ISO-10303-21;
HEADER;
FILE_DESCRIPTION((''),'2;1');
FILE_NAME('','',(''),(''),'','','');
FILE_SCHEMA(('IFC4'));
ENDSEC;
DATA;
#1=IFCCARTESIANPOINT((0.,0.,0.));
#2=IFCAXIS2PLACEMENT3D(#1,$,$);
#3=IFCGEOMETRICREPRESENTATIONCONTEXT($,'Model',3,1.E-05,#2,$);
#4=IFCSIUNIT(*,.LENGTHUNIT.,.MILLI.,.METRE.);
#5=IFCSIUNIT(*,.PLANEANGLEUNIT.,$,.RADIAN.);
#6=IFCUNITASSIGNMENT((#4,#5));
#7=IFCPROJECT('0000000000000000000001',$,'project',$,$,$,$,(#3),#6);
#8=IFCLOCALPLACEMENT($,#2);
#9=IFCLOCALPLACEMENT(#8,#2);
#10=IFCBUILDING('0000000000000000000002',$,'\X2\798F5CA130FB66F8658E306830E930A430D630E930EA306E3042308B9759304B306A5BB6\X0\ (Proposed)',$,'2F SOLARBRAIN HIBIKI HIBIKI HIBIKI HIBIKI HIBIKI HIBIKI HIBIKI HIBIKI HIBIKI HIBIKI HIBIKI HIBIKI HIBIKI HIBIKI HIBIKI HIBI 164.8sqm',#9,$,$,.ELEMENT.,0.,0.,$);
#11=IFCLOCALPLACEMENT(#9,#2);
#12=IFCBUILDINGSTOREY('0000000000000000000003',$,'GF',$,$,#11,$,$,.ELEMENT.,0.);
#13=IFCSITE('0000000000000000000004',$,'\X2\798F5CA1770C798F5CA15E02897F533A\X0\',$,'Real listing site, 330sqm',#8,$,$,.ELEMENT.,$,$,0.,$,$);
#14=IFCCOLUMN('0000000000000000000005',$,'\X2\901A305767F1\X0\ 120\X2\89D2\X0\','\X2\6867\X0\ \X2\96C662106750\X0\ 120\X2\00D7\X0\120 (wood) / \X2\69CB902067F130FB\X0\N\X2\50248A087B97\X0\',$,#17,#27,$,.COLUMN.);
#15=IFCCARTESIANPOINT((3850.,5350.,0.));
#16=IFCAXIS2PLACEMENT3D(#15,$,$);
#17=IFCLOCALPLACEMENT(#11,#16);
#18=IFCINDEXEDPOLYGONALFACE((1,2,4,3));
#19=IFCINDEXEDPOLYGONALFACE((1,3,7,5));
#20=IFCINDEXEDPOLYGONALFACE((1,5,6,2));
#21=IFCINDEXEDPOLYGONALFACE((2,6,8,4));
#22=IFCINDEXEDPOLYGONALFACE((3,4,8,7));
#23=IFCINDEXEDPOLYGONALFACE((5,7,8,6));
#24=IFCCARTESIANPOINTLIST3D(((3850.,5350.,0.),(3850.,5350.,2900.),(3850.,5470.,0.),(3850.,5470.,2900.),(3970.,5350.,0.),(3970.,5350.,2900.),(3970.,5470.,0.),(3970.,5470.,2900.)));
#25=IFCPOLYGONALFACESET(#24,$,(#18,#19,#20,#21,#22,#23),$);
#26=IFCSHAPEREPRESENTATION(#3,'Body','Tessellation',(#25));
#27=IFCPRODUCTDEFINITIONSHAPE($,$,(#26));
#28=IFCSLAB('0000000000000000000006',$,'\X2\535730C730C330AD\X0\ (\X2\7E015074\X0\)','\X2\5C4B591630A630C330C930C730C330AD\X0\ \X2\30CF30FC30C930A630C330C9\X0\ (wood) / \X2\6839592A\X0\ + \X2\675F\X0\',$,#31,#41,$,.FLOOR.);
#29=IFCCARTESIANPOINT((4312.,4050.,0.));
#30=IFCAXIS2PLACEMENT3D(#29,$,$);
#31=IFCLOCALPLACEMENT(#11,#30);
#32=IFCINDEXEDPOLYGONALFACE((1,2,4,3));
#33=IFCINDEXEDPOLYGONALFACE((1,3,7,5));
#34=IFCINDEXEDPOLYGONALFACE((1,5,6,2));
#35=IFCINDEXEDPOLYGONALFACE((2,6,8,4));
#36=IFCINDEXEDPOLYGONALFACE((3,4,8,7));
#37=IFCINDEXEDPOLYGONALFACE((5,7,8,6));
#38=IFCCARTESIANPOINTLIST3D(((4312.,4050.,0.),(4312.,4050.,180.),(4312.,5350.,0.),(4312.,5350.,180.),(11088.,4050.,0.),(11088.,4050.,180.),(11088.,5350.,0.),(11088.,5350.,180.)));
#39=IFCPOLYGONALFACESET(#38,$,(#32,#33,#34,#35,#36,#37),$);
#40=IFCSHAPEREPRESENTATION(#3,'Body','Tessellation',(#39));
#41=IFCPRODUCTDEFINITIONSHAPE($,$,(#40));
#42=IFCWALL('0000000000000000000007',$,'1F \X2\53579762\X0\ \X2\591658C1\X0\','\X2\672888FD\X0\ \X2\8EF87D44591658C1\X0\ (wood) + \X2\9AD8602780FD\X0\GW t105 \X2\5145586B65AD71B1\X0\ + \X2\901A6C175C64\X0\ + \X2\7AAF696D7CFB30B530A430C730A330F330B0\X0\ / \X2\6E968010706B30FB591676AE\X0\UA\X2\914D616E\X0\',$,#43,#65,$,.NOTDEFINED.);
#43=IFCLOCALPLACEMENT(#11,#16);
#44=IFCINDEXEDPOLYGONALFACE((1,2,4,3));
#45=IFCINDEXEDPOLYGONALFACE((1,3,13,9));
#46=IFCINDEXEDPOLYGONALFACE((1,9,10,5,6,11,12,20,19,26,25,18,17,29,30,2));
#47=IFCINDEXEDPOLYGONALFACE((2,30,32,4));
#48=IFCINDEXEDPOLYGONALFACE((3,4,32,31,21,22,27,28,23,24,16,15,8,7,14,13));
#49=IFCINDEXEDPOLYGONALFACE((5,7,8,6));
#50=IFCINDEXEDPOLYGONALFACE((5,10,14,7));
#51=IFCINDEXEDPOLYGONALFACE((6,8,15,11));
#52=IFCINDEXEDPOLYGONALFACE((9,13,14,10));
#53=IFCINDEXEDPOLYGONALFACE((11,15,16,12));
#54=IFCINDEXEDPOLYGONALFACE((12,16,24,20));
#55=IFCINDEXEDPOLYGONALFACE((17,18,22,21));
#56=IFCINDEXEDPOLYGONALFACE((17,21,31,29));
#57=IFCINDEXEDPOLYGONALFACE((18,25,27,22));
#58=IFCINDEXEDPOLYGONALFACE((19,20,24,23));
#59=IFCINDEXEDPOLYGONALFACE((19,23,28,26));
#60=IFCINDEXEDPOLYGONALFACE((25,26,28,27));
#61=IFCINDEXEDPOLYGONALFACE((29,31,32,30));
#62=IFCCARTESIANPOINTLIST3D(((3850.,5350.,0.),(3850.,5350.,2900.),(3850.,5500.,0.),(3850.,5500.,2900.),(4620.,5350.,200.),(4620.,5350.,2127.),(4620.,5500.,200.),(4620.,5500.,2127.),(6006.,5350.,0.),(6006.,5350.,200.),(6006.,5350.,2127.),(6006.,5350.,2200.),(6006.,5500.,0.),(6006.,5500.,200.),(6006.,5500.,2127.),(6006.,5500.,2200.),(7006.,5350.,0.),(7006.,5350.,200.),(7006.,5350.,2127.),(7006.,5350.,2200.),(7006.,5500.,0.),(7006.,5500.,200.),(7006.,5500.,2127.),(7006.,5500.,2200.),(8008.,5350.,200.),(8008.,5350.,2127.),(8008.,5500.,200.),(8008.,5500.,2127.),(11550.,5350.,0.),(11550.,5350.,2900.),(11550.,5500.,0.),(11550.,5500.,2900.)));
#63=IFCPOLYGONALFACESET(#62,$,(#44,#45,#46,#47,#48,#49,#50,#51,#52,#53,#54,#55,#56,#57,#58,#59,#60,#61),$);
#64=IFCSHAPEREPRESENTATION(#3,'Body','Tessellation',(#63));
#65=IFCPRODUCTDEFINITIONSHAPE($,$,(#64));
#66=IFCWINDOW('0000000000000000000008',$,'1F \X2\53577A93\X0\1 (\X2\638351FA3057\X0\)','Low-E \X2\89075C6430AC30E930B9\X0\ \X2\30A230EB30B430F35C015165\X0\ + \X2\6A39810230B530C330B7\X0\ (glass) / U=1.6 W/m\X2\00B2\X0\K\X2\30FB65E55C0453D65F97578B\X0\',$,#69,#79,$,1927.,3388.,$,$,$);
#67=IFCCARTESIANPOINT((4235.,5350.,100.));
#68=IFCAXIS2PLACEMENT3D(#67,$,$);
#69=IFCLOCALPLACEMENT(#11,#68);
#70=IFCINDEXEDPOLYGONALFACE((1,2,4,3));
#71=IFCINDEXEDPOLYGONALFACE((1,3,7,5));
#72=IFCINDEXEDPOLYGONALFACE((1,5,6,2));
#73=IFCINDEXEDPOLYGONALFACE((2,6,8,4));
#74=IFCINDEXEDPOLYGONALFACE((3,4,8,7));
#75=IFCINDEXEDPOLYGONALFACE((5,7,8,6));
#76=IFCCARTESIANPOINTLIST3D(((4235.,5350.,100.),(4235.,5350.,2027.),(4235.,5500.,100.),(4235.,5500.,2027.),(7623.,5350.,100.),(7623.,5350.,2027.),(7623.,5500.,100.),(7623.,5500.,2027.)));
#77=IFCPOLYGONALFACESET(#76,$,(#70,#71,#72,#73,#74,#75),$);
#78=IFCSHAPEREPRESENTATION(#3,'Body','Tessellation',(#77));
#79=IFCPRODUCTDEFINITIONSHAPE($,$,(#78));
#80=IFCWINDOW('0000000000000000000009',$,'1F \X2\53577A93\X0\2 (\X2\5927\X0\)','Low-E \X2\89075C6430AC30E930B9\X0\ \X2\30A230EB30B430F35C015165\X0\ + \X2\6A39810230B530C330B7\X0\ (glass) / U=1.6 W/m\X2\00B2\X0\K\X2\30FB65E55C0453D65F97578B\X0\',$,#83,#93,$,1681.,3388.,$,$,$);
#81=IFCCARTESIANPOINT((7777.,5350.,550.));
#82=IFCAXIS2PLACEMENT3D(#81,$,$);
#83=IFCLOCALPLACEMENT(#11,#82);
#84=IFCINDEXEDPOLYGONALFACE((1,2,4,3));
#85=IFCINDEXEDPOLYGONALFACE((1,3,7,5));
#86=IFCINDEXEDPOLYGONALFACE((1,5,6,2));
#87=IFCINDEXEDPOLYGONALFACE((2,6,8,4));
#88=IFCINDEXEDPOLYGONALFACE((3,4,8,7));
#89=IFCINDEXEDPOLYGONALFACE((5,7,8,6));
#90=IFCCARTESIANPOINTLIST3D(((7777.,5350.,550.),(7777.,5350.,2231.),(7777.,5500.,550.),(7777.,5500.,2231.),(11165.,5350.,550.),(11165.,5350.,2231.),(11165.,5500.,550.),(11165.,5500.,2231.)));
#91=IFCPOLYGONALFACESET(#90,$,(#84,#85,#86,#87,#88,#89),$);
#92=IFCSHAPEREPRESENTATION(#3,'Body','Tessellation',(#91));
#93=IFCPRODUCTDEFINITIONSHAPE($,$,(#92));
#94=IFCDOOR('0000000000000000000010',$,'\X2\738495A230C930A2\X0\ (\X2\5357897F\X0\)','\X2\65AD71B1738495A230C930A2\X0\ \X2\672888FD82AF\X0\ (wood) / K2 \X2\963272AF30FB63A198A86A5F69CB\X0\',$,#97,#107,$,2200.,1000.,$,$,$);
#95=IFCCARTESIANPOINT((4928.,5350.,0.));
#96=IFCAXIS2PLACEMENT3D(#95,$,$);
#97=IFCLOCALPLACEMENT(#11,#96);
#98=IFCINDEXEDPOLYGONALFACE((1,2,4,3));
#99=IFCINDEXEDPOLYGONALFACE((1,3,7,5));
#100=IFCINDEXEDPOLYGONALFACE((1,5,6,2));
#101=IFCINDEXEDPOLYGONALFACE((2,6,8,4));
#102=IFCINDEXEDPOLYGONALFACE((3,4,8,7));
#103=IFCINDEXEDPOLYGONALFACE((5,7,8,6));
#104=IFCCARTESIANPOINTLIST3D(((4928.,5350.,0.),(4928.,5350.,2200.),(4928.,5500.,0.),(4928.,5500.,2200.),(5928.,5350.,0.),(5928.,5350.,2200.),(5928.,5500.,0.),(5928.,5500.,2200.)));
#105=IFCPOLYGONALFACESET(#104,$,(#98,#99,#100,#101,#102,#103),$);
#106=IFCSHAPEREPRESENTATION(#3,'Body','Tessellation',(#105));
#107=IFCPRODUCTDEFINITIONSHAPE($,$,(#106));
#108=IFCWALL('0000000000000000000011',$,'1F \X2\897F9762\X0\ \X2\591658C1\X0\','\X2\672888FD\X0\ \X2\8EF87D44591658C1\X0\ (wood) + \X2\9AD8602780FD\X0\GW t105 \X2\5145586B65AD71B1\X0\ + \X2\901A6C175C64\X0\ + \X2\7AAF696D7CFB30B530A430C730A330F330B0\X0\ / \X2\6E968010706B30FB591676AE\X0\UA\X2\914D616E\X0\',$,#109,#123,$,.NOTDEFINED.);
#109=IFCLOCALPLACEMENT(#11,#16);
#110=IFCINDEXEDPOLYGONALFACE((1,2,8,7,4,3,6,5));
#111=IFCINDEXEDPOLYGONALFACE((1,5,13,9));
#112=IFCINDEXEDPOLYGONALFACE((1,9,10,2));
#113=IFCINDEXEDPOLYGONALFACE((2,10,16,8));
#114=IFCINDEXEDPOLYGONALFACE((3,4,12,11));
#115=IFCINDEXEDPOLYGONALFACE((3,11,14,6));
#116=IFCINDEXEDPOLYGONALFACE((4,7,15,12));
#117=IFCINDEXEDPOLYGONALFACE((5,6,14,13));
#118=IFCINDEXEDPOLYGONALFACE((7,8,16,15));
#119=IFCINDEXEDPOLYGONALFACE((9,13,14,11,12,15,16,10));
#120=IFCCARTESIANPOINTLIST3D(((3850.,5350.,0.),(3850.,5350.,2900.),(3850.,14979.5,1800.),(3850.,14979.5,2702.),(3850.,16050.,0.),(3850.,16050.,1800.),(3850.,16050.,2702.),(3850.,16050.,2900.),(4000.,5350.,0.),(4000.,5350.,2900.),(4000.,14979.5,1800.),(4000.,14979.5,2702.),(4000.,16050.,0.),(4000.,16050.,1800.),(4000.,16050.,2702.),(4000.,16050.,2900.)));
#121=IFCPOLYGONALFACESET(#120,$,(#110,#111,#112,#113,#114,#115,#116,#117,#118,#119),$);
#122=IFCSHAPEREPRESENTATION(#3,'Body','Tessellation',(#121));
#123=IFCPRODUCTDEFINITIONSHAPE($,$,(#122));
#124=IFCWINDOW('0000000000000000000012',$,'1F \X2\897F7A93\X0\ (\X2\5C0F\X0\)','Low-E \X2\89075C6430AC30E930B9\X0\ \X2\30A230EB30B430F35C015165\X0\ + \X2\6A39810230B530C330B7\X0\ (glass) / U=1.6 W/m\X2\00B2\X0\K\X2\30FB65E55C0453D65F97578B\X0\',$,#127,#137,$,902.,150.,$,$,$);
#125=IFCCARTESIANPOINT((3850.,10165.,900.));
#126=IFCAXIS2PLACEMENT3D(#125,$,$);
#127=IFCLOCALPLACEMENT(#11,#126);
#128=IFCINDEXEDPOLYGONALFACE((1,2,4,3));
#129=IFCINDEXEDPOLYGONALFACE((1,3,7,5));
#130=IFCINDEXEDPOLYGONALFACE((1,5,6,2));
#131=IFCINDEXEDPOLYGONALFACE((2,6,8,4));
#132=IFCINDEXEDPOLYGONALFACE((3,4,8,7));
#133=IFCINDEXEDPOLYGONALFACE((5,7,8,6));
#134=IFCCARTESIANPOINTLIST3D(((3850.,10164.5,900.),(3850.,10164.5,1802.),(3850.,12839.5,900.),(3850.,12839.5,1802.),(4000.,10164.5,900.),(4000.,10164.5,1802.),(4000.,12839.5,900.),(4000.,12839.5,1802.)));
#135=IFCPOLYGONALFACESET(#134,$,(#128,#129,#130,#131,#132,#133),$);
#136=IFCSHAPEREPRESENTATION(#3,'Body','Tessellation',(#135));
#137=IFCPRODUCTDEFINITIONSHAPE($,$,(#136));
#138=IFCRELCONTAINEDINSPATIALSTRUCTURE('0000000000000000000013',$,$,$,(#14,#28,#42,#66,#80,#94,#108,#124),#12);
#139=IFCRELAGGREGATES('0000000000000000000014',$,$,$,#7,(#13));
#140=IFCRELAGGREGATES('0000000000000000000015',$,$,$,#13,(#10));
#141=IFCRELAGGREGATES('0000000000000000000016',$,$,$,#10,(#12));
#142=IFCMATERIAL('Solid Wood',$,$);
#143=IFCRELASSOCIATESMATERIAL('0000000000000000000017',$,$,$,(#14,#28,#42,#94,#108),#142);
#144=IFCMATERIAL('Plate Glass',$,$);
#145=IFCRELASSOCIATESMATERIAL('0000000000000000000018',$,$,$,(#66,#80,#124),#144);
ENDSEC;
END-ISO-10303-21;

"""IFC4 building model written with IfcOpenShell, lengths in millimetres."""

from ifc_helpers import new_model, si_unit, frame, frame_2d, origin, place, context, project, spatial, rectangle, extrude, material, element, fill, save


model = new_model("IFC4")

# Units and contexts
model_context = context("Model", 3, precision=1e-05, world=origin())
ifc_project = project(units=[si_unit("LENGTHUNIT", "METRE", prefix="MILLI"), si_unit("PLANEANGLEUNIT", "RADIAN")], contexts=[model_context])

# Site, building, storey
site_placement = place(None, origin())
site = spatial("IfcSite", under=ifc_project, at=site_placement, Name="福岡県福岡市西区", ObjectType="Real listing site, 330sqm", CompositionType="ELEMENT", RefElevation=0.0)
building_placement = place(site_placement, origin())
building = spatial("IfcBuilding", under=site, at=building_placement, Name="福岡・書斎とライブラリのある静かな家 (Proposed)", ObjectType="2F SOLARBRAIN HIBIKI HIBIKI HIBIKI HIBIKI HIBIKI HIBIKI HIBIKI HIBIKI HIBIKI HIBIKI HIBIKI HIBIKI HIBIKI HIBIKI HIBIKI HIBI 164.8sqm", CompositionType="ELEMENT", ElevationOfRefHeight=0.0, ElevationOfTerrain=0.0)
storey_placement = place(building_placement, origin())
storey = spatial("IfcBuildingStorey", under=building, at=storey_placement, Name="GF", CompositionType="ELEMENT", Elevation=0.0)

# Column
ifc_material_1 = material(Name="Solid Wood")
column_placement = place(storey_placement, frame((3850.0, 5350.0, 0.0)))
element("IfcColumn", 1, at=column_placement, inside=storey, material=ifc_material_1, Name="通し柱 120角", Description="桧 集成材 120×120 (wood) / 構造柱・N値計算", PredefinedType="COLUMN", context=model_context, shape_type="SweptSolid", body=[
    extrude(rectangle(XDim=120.0, YDim=120.0, at=frame_2d((60.0, 60.0))), frame((3850.0, 5350.0, 0.0)), (0.0, 0.0, 1.0), 2900.0),
])

# Slab
slab_1_placement = place(storey_placement, frame((4312.0, 4050.0, 0.0)))
element("IfcSlab", 2, at=slab_1_placement, inside=storey, material=ifc_material_1, Name="南デッキ (縁側)", Description="屋外ウッドデッキ ハードウッド (wood) / 根太 + 束", PredefinedType="FLOOR", context=model_context, shape_type="SweptSolid", body=[
    extrude(rectangle(XDim=6776.0, YDim=1300.0, at=frame_2d((3388.0, 650.0))), frame((4312.0, 4050.0, 0.0)), (0.0, 0.0, 1.0), 180.0),
])

# Wall, openings, windows, door
wall_1_placement = place(storey_placement, frame((3850.0, 5350.0, 0.0)))
wall_1 = element("IfcWall", 3, at=wall_1_placement, inside=storey, material=ifc_material_1, Name="1F 南面 外壁", Description="木製 軸組外壁 (wood) + 高性能GW t105 充填断熱 + 通気層 + 窯業系サイディング / 準耐火・外皮UA配慮", PredefinedType="NOTDEFINED", context=model_context, shape_type="SweptSolid", body=[
    extrude(rectangle(XDim=7700.0, YDim=150.0, at=frame_2d((3850.0, 75.0))), frame((3850.0, 5350.0, 0.0)), (0.0, 0.0, 1.0), 2900.0),
])
opening_1_placement = place(storey_placement, frame((4235.0, 5350.0, 100.0)))
opening_1 = element("IfcOpeningElement", 4, at=opening_1_placement, cuts=wall_1, PredefinedType="NOTDEFINED", context=model_context, shape_type="SweptSolid", body=[
    extrude(rectangle(XDim=3388.0, YDim=150.0, at=frame_2d((1694.0, 75.0))), frame((4235.0, 5350.0, 100.0)), (0.0, 0.0, 1.0), 1927.0),
])
opening_2_placement = place(storey_placement, frame((7777.0, 5350.0, 550.0)))
opening_2 = element("IfcOpeningElement", 5, at=opening_2_placement, cuts=wall_1, PredefinedType="NOTDEFINED", context=model_context, shape_type="SweptSolid", body=[
    extrude(rectangle(XDim=3388.0, YDim=150.0, at=frame_2d((1694.0, 75.0))), frame((7777.0, 5350.0, 550.0)), (0.0, 0.0, 1.0), 1681.0),
])
opening_3_placement = place(storey_placement, frame((4928.0, 5350.0, 0.0)))
opening_3 = element("IfcOpeningElement", 6, at=opening_3_placement, cuts=wall_1, PredefinedType="NOTDEFINED", context=model_context, shape_type="SweptSolid", body=[
    extrude(rectangle(XDim=1000.0, YDim=150.0, at=frame_2d((500.0, 75.0))), frame((4928.0, 5350.0, 0.0)), (0.0, 0.0, 1.0), 2200.0),
])
ifc_material_2 = material(Name="Plate Glass")
window_1_placement = place(storey_placement, frame((4235.0, 5350.0, 100.0)))
window_1 = element("IfcWindow", 7, at=window_1_placement, inside=storey, material=ifc_material_2, Name="1F 南窓1 (掃出し)", Description="Low-E 複層ガラス アルゴン封入 + 樹脂サッシ (glass) / U=1.6 W/m²K・日射取得型", OverallHeight=1927.0, OverallWidth=3388.0, context=model_context, shape_type="SweptSolid", body=[
    extrude(rectangle(XDim=3388.0, YDim=150.0, at=frame_2d((1694.0, 75.0))), frame((4235.0, 5350.0, 100.0)), (0.0, 0.0, 1.0), 1927.0),
])
fill(opening_1, window_1)
window_2_placement = place(storey_placement, frame((7777.0, 5350.0, 550.0)))
window_2 = element("IfcWindow", 8, at=window_2_placement, inside=storey, material=ifc_material_2, Name="1F 南窓2 (大)", Description="Low-E 複層ガラス アルゴン封入 + 樹脂サッシ (glass) / U=1.6 W/m²K・日射取得型", OverallHeight=1681.0, OverallWidth=3388.0, context=model_context, shape_type="SweptSolid", body=[
    extrude(rectangle(XDim=3388.0, YDim=150.0, at=frame_2d((1694.0, 75.0))), frame((7777.0, 5350.0, 550.0)), (0.0, 0.0, 1.0), 1681.0),
])
fill(opening_2, window_2)
door_placement = place(storey_placement, frame((4928.0, 5350.0, 0.0)))
door = element("IfcDoor", 9, at=door_placement, inside=storey, material=ifc_material_1, Name="玄関ドア (南西)", Description="断熱玄関ドア 木製芯 (wood) / K2 防犯・採風機構", OverallHeight=2200.0, OverallWidth=1000.0, context=model_context, shape_type="SweptSolid", body=[
    extrude(rectangle(XDim=1000.0, YDim=150.0, at=frame_2d((500.0, 75.0))), frame((4928.0, 5350.0, 0.0)), (0.0, 0.0, 1.0), 2200.0),
])
fill(opening_3, door)

# Wall, opening, window
wall_2_placement = place(storey_placement, frame((3850.0, 5350.0, 0.0)))
wall_2 = element("IfcWall", 10, at=wall_2_placement, inside=storey, material=ifc_material_1, Name="1F 西面 外壁", Description="木製 軸組外壁 (wood) + 高性能GW t105 充填断熱 + 通気層 + 窯業系サイディング / 準耐火・外皮UA配慮", PredefinedType="NOTDEFINED", context=model_context, shape_type="SweptSolid", body=[
    extrude(rectangle(XDim=150.0, YDim=10700.0, at=frame_2d((75.0, 5350.0))), frame((3850.0, 5350.0, 0.0)), (0.0, 0.0, 1.0), 2900.0),
])
opening_4_placement = place(storey_placement, frame((3850.0, 10165.0, 900.0)))
opening_4 = element("IfcOpeningElement", 11, at=opening_4_placement, cuts=wall_2, PredefinedType="NOTDEFINED", context=model_context, shape_type="SweptSolid", body=[
    extrude(rectangle(XDim=150.0, YDim=2675.0, at=frame_2d((75.0, 1337.0))), frame((3850.0, 10165.0, 900.0)), (0.0, 0.0, 1.0), 902.0),
])
window_3_placement = place(storey_placement, frame((3850.0, 10165.0, 900.0)))
window_3 = element("IfcWindow", 12, at=window_3_placement, inside=storey, material=ifc_material_2, Name="1F 西窓 (小)", Description="Low-E 複層ガラス アルゴン封入 + 樹脂サッシ (glass) / U=1.6 W/m²K・日射取得型", OverallHeight=902.0, OverallWidth=150.0, context=model_context, shape_type="SweptSolid", body=[
    extrude(rectangle(XDim=150.0, YDim=2675.0, at=frame_2d((75.0, 1337.0))), frame((3850.0, 10165.0, 900.0)), (0.0, 0.0, 1.0), 902.0),
])
fill(opening_4, window_3)

save(model, "model.ifc")
